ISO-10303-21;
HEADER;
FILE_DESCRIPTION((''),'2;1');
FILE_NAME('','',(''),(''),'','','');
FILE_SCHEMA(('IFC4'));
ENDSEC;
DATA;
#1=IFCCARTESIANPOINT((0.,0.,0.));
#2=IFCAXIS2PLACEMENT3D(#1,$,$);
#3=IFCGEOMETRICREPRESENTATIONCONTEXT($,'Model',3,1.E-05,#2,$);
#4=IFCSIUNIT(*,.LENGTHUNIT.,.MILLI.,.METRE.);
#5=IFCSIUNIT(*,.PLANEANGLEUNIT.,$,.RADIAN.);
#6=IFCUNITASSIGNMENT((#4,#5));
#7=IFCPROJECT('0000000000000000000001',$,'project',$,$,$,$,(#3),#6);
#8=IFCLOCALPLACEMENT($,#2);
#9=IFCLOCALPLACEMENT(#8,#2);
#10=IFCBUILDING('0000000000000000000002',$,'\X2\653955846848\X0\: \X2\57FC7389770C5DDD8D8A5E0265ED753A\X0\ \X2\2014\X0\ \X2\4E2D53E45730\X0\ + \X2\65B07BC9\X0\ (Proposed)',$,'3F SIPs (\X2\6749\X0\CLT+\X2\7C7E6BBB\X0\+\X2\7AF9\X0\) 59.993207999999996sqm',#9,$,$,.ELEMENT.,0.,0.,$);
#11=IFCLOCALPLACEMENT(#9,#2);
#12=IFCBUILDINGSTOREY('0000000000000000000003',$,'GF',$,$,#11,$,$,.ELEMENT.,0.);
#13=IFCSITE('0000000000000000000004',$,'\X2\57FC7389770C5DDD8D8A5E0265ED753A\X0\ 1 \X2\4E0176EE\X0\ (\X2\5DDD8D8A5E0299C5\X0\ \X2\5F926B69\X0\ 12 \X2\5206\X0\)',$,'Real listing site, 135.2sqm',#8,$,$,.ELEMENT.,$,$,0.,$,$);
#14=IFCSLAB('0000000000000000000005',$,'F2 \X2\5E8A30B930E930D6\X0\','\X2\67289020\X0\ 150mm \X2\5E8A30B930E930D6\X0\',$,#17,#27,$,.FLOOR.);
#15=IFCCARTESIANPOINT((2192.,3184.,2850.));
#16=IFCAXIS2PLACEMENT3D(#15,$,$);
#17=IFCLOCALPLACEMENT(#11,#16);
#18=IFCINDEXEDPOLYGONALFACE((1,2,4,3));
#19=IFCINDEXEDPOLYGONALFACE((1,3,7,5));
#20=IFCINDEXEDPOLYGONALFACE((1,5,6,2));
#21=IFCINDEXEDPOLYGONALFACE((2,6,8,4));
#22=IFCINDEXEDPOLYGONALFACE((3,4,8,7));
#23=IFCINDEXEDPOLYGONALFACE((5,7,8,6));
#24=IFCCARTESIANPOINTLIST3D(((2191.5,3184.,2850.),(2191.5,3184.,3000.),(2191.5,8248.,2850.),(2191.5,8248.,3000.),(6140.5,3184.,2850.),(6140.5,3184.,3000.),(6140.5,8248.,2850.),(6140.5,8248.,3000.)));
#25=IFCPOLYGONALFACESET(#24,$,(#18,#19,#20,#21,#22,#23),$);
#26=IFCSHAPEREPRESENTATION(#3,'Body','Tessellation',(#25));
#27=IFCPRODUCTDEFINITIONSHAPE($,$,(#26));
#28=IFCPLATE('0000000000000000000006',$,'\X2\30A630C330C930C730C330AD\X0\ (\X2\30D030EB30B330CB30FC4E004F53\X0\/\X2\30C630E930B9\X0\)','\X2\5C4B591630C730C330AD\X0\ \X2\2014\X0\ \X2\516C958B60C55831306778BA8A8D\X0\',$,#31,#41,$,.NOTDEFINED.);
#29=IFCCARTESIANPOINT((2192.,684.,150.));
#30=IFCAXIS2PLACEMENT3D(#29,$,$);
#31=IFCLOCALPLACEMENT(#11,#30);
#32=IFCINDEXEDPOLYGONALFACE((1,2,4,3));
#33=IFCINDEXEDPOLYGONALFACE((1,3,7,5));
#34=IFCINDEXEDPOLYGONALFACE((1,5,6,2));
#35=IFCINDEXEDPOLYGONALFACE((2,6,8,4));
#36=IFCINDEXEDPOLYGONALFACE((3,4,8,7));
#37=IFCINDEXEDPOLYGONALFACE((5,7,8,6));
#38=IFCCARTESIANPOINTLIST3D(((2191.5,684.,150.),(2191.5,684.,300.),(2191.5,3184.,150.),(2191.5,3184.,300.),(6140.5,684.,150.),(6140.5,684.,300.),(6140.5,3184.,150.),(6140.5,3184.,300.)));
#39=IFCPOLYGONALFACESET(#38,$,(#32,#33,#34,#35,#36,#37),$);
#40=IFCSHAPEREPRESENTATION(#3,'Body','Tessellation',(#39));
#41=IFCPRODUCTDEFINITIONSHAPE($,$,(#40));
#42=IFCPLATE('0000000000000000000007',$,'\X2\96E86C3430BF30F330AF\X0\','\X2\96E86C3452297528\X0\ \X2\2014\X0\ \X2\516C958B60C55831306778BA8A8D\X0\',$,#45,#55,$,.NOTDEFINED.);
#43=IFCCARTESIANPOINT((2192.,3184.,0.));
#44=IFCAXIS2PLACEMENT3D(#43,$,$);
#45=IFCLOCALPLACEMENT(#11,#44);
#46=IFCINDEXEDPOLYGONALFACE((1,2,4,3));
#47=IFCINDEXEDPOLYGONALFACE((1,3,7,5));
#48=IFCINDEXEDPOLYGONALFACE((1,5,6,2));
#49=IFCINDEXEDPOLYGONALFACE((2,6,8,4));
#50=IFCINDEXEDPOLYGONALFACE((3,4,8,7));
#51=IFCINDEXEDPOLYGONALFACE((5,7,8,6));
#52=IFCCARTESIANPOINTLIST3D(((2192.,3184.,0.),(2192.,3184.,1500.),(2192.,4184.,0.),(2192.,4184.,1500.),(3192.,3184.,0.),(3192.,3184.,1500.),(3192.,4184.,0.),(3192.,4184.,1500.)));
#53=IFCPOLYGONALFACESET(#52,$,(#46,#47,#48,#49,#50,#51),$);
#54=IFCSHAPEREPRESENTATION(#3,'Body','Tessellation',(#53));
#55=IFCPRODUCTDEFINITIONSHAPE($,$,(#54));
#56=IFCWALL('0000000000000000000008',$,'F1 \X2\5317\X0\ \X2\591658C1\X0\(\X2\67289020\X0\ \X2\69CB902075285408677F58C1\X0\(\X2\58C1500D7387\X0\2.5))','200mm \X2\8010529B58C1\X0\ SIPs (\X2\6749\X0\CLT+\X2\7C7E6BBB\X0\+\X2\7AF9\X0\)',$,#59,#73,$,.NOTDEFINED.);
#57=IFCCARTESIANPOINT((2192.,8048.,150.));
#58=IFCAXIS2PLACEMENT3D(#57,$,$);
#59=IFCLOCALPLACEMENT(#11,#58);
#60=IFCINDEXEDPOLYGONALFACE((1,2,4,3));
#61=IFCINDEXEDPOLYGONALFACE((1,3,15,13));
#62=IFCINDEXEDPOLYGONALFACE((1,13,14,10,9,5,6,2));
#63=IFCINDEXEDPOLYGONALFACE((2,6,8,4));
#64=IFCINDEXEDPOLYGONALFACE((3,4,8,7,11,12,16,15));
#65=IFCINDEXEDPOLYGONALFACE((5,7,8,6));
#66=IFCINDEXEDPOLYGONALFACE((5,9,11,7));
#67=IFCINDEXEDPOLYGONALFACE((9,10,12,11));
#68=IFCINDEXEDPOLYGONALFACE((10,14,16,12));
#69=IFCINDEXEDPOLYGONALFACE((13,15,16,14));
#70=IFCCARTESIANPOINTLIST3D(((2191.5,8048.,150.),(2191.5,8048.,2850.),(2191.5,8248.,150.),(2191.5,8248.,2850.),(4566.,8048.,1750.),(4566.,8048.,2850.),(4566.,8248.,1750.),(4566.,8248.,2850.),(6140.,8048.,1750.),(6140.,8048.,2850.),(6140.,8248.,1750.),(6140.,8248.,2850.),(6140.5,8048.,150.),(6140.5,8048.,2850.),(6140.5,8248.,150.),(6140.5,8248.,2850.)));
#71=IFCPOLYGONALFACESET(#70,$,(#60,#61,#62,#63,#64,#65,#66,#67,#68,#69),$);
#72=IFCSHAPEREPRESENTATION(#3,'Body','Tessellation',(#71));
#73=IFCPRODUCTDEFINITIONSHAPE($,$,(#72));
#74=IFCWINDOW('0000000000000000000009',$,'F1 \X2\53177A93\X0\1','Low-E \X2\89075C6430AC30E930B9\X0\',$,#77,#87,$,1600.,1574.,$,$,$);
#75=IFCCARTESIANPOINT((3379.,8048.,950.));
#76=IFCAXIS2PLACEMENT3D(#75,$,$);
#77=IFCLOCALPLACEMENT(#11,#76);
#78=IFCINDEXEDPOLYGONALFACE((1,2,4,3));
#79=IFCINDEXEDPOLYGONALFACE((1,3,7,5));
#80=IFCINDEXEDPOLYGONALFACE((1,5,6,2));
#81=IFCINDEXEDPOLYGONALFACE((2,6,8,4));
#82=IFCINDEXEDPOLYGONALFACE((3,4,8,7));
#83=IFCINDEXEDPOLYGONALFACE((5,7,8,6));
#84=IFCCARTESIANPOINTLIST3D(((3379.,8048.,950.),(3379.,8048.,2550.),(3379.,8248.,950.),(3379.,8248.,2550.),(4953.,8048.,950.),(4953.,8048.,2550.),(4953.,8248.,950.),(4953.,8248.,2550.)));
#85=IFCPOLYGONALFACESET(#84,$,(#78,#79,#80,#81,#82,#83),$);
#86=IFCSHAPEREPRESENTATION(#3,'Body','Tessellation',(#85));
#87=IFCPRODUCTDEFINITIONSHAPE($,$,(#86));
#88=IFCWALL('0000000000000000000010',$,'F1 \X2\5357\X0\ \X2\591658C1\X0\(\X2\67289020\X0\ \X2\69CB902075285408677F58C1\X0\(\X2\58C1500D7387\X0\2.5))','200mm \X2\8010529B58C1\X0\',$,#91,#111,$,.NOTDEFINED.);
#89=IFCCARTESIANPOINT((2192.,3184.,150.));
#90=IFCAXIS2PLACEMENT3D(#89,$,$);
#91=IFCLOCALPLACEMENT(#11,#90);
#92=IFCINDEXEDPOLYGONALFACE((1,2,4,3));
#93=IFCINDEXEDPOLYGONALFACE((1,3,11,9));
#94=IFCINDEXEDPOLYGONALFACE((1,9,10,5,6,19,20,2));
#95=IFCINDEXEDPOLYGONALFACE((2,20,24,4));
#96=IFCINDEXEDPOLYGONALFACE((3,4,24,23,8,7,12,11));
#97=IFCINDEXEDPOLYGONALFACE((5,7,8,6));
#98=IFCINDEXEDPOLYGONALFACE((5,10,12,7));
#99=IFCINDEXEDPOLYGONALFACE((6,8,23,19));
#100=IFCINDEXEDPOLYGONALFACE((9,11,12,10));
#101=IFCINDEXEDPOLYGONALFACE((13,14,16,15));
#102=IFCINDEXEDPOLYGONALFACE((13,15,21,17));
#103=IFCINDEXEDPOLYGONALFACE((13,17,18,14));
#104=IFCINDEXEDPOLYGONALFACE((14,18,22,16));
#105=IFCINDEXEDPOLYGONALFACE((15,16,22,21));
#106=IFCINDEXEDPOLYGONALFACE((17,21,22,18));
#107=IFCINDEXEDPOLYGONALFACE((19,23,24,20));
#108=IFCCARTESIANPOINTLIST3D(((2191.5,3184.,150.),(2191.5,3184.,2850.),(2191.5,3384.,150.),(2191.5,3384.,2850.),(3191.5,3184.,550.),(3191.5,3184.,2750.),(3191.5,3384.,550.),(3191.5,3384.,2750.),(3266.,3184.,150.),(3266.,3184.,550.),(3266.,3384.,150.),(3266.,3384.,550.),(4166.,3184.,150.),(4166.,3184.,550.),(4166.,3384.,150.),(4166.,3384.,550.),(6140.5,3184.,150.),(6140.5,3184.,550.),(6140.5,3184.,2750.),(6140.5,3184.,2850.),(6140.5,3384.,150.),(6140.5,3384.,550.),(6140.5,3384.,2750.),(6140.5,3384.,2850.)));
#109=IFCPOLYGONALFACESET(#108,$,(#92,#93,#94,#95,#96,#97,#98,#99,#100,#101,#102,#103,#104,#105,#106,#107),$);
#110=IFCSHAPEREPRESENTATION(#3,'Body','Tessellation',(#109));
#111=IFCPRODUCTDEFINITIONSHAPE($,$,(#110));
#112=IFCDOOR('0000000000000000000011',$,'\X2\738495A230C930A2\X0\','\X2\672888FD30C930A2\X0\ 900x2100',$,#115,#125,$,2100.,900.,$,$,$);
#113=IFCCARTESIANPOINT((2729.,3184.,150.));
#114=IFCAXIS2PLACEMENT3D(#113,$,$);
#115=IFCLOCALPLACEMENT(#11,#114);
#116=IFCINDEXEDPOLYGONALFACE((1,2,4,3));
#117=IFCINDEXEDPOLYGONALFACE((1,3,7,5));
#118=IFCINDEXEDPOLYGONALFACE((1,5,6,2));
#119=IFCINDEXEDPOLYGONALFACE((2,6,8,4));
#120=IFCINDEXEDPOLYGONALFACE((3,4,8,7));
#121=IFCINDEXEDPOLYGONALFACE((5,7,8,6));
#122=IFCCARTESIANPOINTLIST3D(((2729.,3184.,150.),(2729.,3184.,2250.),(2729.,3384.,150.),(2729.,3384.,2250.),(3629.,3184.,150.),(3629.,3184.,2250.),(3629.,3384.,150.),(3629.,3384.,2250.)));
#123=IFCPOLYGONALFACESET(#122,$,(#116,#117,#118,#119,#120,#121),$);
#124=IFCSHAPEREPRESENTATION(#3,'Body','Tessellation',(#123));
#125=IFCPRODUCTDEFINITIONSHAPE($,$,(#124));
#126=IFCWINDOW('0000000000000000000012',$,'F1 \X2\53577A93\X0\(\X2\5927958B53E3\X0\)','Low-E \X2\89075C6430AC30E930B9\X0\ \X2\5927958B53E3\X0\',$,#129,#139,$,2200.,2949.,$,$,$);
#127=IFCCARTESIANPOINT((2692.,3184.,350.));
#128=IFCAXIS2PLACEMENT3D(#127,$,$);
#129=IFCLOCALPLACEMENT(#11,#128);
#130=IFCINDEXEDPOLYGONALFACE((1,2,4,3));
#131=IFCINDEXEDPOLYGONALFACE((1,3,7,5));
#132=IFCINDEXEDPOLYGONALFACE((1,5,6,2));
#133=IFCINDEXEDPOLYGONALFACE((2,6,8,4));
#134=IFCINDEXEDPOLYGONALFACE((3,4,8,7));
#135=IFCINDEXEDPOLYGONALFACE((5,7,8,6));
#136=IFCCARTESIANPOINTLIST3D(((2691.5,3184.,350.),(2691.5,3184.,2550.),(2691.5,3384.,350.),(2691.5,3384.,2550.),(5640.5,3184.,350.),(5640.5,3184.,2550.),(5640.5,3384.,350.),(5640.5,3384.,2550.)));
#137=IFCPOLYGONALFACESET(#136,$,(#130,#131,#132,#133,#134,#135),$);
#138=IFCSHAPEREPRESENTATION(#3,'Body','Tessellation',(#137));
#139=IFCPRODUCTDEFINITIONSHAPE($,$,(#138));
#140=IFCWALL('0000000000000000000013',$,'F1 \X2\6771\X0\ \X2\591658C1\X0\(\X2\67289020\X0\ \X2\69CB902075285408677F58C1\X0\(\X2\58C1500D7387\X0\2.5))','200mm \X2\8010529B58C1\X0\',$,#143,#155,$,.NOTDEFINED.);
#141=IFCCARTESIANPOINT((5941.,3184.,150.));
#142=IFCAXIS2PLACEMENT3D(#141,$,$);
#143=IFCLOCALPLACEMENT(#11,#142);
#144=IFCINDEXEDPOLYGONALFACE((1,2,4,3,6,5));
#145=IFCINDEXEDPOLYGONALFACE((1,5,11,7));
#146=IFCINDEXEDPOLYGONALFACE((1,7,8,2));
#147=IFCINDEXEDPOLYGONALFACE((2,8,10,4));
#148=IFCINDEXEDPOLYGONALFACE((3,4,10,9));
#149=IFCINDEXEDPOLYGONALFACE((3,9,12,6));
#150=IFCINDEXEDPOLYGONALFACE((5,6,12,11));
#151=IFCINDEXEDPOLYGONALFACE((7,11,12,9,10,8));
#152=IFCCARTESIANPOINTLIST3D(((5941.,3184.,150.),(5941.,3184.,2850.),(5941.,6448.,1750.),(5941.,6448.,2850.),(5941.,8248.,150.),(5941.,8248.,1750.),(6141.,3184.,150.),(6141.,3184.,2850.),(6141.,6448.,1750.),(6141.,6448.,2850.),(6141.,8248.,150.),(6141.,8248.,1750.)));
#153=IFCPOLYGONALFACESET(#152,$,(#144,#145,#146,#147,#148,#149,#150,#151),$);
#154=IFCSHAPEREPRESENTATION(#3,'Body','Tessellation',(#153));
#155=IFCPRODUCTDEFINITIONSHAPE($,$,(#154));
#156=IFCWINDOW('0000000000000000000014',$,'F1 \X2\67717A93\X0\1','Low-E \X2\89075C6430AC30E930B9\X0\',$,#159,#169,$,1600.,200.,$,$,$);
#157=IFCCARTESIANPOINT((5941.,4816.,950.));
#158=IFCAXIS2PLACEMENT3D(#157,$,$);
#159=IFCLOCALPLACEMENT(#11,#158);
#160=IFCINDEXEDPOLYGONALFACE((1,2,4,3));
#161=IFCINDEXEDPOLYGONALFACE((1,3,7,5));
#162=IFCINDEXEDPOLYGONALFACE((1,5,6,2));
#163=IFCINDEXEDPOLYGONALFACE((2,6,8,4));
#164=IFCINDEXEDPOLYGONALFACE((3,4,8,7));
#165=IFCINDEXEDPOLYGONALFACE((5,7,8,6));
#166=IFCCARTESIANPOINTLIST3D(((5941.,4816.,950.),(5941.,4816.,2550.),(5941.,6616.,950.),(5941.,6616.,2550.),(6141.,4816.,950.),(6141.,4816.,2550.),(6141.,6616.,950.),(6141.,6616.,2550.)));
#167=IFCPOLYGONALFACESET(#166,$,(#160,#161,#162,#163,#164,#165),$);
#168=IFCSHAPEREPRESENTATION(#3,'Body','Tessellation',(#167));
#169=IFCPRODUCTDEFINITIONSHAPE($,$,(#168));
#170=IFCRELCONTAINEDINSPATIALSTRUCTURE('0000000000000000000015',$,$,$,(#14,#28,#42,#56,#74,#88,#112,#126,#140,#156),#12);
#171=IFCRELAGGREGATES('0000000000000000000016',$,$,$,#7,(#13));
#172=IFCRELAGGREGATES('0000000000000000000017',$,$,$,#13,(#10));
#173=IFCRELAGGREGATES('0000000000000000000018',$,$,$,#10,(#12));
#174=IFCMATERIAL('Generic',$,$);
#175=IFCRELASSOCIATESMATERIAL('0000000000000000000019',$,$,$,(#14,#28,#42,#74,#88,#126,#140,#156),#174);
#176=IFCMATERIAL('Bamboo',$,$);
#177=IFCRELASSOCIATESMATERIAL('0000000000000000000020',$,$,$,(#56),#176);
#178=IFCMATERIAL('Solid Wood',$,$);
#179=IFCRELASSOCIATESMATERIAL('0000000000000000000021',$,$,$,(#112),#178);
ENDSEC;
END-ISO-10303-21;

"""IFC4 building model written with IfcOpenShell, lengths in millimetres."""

from ifc_helpers import new_model, si_unit, frame, frame_2d, origin, place, context, project, spatial, rectangle, extrude, material, element, fill, save


model = new_model("IFC4")

# Units and contexts
model_context = context("Model", 3, precision=1e-05, world=origin())
ifc_project = project(units=[si_unit("LENGTHUNIT", "METRE", prefix="MILLI"), si_unit("PLANEANGLEUNIT", "RADIAN")], contexts=[model_context])

# Site, building, storey
site_placement = place(None, origin())
site = spatial("IfcSite", under=ifc_project, at=site_placement, Name="埼玉県川越市旭町 1 丁目 (川越市駅 徒歩 12 分)", ObjectType="Real listing site, 135.2sqm", CompositionType="ELEMENT", RefElevation=0.0)
building_placement = place(site_placement, origin())
building = spatial("IfcBuilding", under=site, at=building_placement, Name="改善案: 埼玉県川越市旭町 — 中古地 + 新築 (Proposed)", ObjectType="3F SIPs (杉CLT+籾殻+竹) 59.993207999999996sqm", CompositionType="ELEMENT", ElevationOfRefHeight=0.0, ElevationOfTerrain=0.0)
storey_placement = place(building_placement, origin())
storey = spatial("IfcBuildingStorey", under=building, at=storey_placement, Name="GF", CompositionType="ELEMENT", Elevation=0.0)

# Slab
ifc_material_1 = material(Name="Generic")
slab_1_placement = place(storey_placement, frame((2192.0, 3184.0, 2850.0)))
element("IfcSlab", 1, at=slab_1_placement, inside=storey, material=ifc_material_1, Name="F2 床スラブ", Description="木造 150mm 床スラブ", PredefinedType="FLOOR", context=model_context, shape_type="SweptSolid", body=[
    extrude(rectangle(XDim=3949.0, YDim=5064.0, at=frame_2d((1974.0, 2532.0))), frame((2192.0, 3184.0, 2850.0)), (0.0, 0.0, 1.0), 150.0),
])

# Plates
plate_1_placement = place(storey_placement, frame((2192.0, 684.0, 150.0)))
element("IfcPlate", 2, at=plate_1_placement, inside=storey, material=ifc_material_1, Name="ウッドデッキ (バルコニー一体/テラス)", Description="屋外デッキ — 公開情報で確認", PredefinedType="NOTDEFINED", context=model_context, shape_type="SweptSolid", body=[
    extrude(rectangle(XDim=3949.0, YDim=2500.0, at=frame_2d((1974.0, 1250.0))), frame((2192.0, 684.0, 150.0)), (0.0, 0.0, 1.0), 150.0),
])
plate_2_placement = place(storey_placement, frame((2192.0, 3184.0, 0.0)))
element("IfcPlate", 3, at=plate_2_placement, inside=storey, material=ifc_material_1, Name="雨水タンク", Description="雨水利用 — 公開情報で確認", PredefinedType="NOTDEFINED", context=model_context, shape_type="SweptSolid", body=[
    extrude(rectangle(XDim=1000.0, YDim=1000.0, at=frame_2d((500.0, 500.0))), frame((2192.0, 3184.0, 0.0)), (0.0, 0.0, 1.0), 1500.0),
])

# Wall, opening, window
ifc_material_2 = material(Name="Bamboo")
wall_1_placement = place(storey_placement, frame((2192.0, 8048.0, 150.0)))
wall_1 = element("IfcWall", 4, at=wall_1_placement, inside=storey, material=ifc_material_2, Name="F1 北 外壁(木造 構造用合板壁(壁倍率2.5))", Description="200mm 耐力壁 SIPs (杉CLT+籾殻+竹)", PredefinedType="NOTDEFINED", context=model_context, shape_type="SweptSolid", body=[
    extrude(rectangle(XDim=3949.0, YDim=200.0, at=frame_2d((1974.0, 100.0))), frame((2192.0, 8048.0, 150.0)), (0.0, 0.0, 1.0), 2700.0),
])
opening_1_placement = place(storey_placement, frame((3379.0, 8048.0, 950.0)))
opening_1 = element("IfcOpeningElement", 5, at=opening_1_placement, cuts=wall_1, PredefinedType="NOTDEFINED", context=model_context, shape_type="SweptSolid", body=[
    extrude(rectangle(XDim=1574.0, YDim=200.0, at=frame_2d((787.0, 100.0))), frame((3379.0, 8048.0, 950.0)), (0.0, 0.0, 1.0), 1600.0),
])
window_1_placement = place(storey_placement, frame((3379.0, 8048.0, 950.0)))
window_1 = element("IfcWindow", 6, at=window_1_placement, inside=storey, material=ifc_material_1, Name="F1 北窓1", Description="Low-E 複層ガラス", OverallHeight=1600.0, OverallWidth=1574.0, context=model_context, shape_type="SweptSolid", body=[
    extrude(rectangle(XDim=1574.0, YDim=200.0, at=frame_2d((787.0, 100.0))), frame((3379.0, 8048.0, 950.0)), (0.0, 0.0, 1.0), 1600.0),
])
fill(opening_1, window_1)

# Wall, openings, door, window
wall_2_placement = place(storey_placement, frame((2192.0, 3184.0, 150.0)))
wall_2 = element("IfcWall", 7, at=wall_2_placement, inside=storey, material=ifc_material_1, Name="F1 南 外壁(木造 構造用合板壁(壁倍率2.5))", Description="200mm 耐力壁", PredefinedType="NOTDEFINED", context=model_context, shape_type="SweptSolid", body=[
    extrude(rectangle(XDim=3949.0, YDim=200.0, at=frame_2d((1974.0, 100.0))), frame((2192.0, 3184.0, 150.0)), (0.0, 0.0, 1.0), 2700.0),
])
opening_2_placement = place(storey_placement, frame((2729.0, 3184.0, 150.0)))
opening_2 = element("IfcOpeningElement", 8, at=opening_2_placement, cuts=wall_2, PredefinedType="NOTDEFINED", context=model_context, shape_type="SweptSolid", body=[
    extrude(rectangle(XDim=900.0, YDim=200.0, at=frame_2d((450.0, 100.0))), frame((2729.0, 3184.0, 150.0)), (0.0, 0.0, 1.0), 2100.0),
])
opening_3_placement = place(storey_placement, frame((2692.0, 3184.0, 350.0)))
opening_3 = element("IfcOpeningElement", 9, at=opening_3_placement, cuts=wall_2, PredefinedType="NOTDEFINED", context=model_context, shape_type="SweptSolid", body=[
    extrude(rectangle(XDim=2949.0, YDim=200.0, at=frame_2d((1474.0, 100.0))), frame((2692.0, 3184.0, 350.0)), (0.0, 0.0, 1.0), 2200.0),
])
ifc_material_3 = material(Name="Solid Wood")
door_placement = place(storey_placement, frame((2729.0, 3184.0, 150.0)))
door = element("IfcDoor", 10, at=door_placement, inside=storey, material=ifc_material_3, Name="玄関ドア", Description="木製ドア 900x2100", OverallHeight=2100.0, OverallWidth=900.0, context=model_context, shape_type="SweptSolid", body=[
    extrude(rectangle(XDim=900.0, YDim=200.0, at=frame_2d((450.0, 100.0))), frame((2729.0, 3184.0, 150.0)), (0.0, 0.0, 1.0), 2100.0),
])
fill(opening_2, door)
window_2_placement = place(storey_placement, frame((2692.0, 3184.0, 350.0)))
window_2 = element("IfcWindow", 11, at=window_2_placement, inside=storey, material=ifc_material_1, Name="F1 南窓(大開口)", Description="Low-E 複層ガラス 大開口", OverallHeight=2200.0, OverallWidth=2949.0, context=model_context, shape_type="SweptSolid", body=[
    extrude(rectangle(XDim=2949.0, YDim=200.0, at=frame_2d((1474.0, 100.0))), frame((2692.0, 3184.0, 350.0)), (0.0, 0.0, 1.0), 2200.0),
])
fill(opening_3, window_2)

# Wall, opening, window
wall_3_placement = place(storey_placement, frame((5941.0, 3184.0, 150.0)))
wall_3 = element("IfcWall", 12, at=wall_3_placement, inside=storey, material=ifc_material_1, Name="F1 東 外壁(木造 構造用合板壁(壁倍率2.5))", Description="200mm 耐力壁", PredefinedType="NOTDEFINED", context=model_context, shape_type="SweptSolid", body=[
    extrude(rectangle(XDim=200.0, YDim=5064.0, at=frame_2d((100.0, 2532.0))), frame((5941.0, 3184.0, 150.0)), (0.0, 0.0, 1.0), 2700.0),
])
opening_4_placement = place(storey_placement, frame((5941.0, 4816.0, 950.0)))
opening_4 = element("IfcOpeningElement", 13, at=opening_4_placement, cuts=wall_3, PredefinedType="NOTDEFINED", context=model_context, shape_type="SweptSolid", body=[
    extrude(rectangle(XDim=200.0, YDim=1800.0, at=frame_2d((100.0, 900.0))), frame((5941.0, 4816.0, 950.0)), (0.0, 0.0, 1.0), 1600.0),
])
window_3_placement = place(storey_placement, frame((5941.0, 4816.0, 950.0)))
window_3 = element("IfcWindow", 14, at=window_3_placement, inside=storey, material=ifc_material_1, Name="F1 東窓1", Description="Low-E 複層ガラス", OverallHeight=1600.0, OverallWidth=200.0, context=model_context, shape_type="SweptSolid", body=[
    extrude(rectangle(XDim=200.0, YDim=1800.0, at=frame_2d((100.0, 900.0))), frame((5941.0, 4816.0, 950.0)), (0.0, 0.0, 1.0), 1600.0),
])
fill(opening_4, window_3)

save(model, "model.ifc")
